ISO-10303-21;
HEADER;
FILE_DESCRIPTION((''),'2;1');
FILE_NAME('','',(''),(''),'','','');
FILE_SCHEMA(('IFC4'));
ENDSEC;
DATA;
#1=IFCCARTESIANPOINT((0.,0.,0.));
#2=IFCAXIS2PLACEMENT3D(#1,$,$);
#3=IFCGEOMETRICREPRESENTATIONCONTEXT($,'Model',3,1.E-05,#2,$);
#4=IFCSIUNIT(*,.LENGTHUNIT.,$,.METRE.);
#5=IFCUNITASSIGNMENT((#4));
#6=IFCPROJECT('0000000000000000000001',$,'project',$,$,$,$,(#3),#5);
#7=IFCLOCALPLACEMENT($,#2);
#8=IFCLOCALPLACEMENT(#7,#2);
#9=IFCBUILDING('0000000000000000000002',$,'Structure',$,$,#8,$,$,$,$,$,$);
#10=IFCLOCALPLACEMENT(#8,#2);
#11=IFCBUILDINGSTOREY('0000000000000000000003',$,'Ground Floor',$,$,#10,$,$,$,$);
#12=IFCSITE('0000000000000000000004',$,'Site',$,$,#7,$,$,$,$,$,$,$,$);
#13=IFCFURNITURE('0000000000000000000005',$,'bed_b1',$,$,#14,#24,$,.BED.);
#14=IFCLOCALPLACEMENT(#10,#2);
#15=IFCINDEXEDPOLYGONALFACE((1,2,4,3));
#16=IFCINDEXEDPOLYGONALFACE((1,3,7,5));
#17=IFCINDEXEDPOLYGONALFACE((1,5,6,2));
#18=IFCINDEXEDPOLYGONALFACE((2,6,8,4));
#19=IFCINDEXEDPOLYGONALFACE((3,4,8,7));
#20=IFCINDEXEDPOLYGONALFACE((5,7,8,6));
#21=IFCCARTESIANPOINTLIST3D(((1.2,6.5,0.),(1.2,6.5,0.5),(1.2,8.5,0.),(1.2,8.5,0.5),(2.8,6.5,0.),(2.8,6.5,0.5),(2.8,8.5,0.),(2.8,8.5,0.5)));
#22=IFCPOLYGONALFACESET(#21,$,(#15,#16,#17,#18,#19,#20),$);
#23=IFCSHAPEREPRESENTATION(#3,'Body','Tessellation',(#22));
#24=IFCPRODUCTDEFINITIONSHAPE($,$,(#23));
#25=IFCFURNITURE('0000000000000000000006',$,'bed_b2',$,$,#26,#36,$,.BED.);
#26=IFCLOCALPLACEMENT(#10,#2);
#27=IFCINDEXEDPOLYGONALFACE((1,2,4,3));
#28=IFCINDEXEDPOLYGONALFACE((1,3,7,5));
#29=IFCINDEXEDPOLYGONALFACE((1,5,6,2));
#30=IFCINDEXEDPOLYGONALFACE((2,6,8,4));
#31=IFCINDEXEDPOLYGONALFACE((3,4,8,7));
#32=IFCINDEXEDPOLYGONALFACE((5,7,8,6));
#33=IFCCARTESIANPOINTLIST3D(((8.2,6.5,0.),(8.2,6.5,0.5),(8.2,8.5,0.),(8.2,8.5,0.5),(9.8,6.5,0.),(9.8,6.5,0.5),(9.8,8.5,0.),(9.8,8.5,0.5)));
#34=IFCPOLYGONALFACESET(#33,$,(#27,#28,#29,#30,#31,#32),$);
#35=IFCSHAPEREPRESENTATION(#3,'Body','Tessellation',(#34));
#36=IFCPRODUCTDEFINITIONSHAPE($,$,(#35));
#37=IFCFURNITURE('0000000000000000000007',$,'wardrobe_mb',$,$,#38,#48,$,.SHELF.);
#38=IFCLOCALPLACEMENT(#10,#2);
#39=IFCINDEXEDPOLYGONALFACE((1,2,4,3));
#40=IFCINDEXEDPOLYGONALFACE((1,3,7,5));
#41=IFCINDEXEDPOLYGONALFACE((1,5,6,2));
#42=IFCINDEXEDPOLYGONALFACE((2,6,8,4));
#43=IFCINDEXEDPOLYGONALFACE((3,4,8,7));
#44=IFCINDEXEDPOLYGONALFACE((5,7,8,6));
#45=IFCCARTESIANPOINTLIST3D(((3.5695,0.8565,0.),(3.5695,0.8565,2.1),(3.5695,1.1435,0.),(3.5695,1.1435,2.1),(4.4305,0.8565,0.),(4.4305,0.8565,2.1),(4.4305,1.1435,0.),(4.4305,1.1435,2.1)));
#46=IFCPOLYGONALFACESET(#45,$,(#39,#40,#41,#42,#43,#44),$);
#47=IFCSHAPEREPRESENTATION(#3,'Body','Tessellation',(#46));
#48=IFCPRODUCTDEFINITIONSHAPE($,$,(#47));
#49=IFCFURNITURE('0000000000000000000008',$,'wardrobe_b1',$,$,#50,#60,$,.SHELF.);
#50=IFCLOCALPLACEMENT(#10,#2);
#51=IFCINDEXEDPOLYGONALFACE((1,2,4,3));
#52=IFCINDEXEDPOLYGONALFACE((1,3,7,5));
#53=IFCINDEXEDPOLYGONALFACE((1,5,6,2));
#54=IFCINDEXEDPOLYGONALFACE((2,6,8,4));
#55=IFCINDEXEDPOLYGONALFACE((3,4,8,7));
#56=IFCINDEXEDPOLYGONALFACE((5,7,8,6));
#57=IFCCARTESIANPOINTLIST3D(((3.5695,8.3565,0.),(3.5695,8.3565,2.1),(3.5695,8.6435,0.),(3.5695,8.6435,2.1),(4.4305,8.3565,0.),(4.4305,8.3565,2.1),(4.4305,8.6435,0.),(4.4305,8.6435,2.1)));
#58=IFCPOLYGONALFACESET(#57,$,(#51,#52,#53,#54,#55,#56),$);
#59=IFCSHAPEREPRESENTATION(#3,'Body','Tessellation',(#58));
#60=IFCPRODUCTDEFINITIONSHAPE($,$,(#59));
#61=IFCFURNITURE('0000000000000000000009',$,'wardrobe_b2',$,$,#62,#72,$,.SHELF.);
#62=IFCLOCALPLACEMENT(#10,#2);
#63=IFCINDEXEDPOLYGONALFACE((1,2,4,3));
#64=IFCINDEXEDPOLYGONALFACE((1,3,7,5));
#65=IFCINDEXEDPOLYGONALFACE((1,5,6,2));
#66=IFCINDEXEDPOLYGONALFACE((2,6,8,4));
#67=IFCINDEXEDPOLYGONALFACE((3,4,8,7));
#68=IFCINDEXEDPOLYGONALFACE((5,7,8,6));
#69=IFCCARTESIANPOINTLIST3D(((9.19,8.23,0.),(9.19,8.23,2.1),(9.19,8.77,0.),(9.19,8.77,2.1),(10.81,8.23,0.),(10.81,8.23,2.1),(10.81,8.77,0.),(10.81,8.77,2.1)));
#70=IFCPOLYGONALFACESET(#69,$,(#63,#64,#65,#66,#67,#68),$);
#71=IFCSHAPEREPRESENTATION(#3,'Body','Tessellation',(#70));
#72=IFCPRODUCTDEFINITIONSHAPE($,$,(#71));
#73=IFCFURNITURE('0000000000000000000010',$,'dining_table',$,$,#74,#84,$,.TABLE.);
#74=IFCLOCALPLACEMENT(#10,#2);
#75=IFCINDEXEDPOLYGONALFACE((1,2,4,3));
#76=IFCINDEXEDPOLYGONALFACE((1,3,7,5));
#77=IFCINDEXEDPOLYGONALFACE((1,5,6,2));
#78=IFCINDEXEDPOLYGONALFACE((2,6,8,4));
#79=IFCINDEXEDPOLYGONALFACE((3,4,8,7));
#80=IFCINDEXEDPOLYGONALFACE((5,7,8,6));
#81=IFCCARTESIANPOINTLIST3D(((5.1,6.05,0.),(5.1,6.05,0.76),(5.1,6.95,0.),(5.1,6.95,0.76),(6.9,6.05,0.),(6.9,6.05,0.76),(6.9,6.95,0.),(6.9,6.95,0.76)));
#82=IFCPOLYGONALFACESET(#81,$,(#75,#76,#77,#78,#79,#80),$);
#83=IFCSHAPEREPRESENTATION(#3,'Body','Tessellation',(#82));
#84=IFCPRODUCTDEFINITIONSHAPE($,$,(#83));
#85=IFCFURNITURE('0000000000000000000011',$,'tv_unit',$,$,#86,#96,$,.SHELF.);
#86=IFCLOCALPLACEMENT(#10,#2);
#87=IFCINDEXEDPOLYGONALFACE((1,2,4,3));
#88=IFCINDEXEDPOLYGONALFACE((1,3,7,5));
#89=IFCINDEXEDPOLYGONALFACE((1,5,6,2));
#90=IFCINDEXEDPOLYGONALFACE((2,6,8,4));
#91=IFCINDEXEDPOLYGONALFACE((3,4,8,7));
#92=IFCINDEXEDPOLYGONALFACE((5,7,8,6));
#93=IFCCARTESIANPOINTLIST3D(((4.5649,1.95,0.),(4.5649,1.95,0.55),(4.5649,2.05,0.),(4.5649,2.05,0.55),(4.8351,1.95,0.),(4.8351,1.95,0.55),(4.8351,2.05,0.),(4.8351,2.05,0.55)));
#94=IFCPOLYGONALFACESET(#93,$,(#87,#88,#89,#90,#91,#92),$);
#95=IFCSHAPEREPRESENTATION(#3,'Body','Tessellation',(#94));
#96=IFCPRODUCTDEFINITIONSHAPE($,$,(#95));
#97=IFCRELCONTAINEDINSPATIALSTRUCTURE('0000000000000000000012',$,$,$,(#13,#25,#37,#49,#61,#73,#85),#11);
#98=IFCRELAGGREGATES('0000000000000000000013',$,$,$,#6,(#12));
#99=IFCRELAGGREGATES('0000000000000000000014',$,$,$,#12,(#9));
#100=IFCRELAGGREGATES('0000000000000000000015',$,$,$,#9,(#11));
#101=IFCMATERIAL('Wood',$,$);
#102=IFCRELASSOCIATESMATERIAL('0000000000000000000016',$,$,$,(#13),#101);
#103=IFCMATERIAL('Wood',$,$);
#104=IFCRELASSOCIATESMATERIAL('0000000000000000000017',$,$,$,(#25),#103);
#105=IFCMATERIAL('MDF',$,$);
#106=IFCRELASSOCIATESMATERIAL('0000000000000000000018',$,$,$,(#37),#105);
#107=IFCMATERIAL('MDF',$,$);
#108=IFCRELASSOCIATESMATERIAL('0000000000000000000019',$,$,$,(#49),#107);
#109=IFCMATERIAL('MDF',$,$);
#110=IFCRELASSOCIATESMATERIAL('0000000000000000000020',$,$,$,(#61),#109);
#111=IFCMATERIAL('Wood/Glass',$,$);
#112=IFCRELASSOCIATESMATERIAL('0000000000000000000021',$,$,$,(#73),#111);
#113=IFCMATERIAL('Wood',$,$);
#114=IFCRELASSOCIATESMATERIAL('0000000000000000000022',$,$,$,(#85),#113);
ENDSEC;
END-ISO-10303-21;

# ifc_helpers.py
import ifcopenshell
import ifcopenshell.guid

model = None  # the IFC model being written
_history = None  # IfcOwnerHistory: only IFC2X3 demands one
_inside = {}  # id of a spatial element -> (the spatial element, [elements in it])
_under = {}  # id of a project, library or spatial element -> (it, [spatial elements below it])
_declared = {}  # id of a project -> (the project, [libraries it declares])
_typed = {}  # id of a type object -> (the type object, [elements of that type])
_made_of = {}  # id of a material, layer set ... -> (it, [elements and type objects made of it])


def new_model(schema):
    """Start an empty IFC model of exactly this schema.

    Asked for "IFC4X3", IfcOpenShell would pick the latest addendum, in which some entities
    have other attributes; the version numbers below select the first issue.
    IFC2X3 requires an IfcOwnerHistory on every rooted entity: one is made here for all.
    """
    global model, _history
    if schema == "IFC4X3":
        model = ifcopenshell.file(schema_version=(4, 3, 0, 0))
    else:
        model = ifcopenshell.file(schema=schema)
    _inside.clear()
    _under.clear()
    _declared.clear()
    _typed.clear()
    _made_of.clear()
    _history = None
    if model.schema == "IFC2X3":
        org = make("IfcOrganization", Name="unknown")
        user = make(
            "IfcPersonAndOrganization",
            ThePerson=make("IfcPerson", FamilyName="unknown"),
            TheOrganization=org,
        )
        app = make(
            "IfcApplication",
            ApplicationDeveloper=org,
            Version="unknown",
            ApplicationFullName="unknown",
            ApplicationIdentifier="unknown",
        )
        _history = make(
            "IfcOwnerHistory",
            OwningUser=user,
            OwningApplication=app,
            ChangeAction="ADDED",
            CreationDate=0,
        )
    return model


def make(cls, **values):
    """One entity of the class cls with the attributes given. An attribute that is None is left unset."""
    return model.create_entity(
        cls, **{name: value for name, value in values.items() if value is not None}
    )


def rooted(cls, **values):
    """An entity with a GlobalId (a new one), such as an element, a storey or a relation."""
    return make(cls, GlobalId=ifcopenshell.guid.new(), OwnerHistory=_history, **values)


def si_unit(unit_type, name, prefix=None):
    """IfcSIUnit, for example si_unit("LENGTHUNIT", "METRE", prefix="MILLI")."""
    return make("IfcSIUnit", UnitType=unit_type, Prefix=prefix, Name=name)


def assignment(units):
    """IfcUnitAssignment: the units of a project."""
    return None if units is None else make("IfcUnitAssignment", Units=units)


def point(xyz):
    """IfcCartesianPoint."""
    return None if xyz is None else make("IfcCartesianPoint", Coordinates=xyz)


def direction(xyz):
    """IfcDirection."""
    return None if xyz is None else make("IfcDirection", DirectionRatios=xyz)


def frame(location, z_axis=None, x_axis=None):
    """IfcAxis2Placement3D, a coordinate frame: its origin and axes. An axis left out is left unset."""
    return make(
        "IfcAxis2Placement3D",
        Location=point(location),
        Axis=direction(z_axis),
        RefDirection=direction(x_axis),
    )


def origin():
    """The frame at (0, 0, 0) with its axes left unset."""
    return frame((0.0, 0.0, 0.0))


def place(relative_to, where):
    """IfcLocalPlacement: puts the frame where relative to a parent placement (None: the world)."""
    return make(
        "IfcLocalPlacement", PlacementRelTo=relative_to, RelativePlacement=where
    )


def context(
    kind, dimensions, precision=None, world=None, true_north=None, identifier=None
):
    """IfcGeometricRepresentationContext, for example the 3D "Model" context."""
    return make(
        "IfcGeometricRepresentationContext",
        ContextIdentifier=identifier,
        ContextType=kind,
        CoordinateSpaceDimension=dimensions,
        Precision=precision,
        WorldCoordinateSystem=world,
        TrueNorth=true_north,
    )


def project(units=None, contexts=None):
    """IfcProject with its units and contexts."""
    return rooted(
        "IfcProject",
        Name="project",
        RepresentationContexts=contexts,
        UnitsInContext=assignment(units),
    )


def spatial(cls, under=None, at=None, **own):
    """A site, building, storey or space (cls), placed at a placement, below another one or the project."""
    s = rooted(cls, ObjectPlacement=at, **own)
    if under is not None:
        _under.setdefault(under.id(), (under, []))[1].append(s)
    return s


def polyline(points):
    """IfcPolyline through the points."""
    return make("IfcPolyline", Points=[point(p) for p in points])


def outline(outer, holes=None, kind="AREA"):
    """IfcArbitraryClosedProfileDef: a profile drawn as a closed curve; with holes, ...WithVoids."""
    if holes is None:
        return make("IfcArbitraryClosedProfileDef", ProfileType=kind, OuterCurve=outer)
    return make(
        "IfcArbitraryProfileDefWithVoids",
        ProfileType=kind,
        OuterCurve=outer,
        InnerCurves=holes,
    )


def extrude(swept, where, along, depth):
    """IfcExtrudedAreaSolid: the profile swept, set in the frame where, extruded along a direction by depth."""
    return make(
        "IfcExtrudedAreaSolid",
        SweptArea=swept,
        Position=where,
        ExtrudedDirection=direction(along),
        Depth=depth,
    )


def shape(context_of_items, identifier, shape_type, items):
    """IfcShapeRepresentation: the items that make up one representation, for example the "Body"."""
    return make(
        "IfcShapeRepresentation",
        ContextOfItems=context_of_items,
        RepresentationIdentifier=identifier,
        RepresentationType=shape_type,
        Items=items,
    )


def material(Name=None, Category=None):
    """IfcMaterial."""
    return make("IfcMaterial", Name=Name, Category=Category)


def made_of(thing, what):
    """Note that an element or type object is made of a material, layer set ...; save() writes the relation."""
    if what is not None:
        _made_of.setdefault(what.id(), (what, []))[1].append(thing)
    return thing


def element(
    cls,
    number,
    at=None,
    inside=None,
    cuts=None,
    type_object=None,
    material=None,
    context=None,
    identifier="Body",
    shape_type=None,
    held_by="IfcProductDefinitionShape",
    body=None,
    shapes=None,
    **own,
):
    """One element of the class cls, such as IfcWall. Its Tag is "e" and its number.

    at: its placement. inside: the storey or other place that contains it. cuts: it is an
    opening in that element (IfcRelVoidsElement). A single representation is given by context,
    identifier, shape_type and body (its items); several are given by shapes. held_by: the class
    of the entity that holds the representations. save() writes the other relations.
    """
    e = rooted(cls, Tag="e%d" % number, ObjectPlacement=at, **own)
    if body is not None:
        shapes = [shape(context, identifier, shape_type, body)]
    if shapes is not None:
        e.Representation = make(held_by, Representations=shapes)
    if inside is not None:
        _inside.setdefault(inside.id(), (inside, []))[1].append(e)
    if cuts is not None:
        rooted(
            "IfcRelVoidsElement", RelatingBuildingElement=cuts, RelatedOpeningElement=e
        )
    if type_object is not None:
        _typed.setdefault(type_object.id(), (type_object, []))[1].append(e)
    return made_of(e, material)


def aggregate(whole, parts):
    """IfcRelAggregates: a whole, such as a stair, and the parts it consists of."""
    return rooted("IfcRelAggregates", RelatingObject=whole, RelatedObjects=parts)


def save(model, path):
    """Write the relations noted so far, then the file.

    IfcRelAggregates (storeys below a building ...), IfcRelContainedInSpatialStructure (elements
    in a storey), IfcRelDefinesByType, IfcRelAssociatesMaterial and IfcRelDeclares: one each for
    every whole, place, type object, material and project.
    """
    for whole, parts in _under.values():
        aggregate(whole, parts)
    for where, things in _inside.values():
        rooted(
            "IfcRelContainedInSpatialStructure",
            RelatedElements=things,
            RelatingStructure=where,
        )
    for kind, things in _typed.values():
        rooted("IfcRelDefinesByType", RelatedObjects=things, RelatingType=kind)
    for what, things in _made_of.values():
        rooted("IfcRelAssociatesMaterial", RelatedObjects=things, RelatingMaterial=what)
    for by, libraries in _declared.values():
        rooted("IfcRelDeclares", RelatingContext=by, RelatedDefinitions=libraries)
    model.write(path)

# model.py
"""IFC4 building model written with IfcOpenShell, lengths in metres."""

from ifc_helpers import new_model, si_unit, frame, origin, place, context, project, spatial, polyline, outline, extrude, material, element, save


model = new_model("IFC4")

# Units and contexts
model_context = context("Model", 3, precision=1e-05, world=origin())
ifc_project = project(units=[si_unit("LENGTHUNIT", "METRE")], contexts=[model_context])

# Site, building, storey
site_placement = place(None, origin())
site = spatial("IfcSite", under=ifc_project, at=site_placement, Name="Site")
building_placement = place(site_placement, origin())
building = spatial("IfcBuilding", under=site, at=building_placement, Name="Structure")
storey_placement = place(building_placement, origin())
storey = spatial("IfcBuildingStorey", under=building, at=storey_placement, Name="Ground Floor")

# Furniture
ifc_material_1 = material(Name="Wood")
furniture_1_placement = place(storey_placement, frame((2.0, 7.5, 0.0)))
element("IfcFurniture", 1, at=furniture_1_placement, inside=storey, material=ifc_material_1, Name="bed_b1", PredefinedType="BED", context=model_context, shape_type="SweptSolid", body=[
    extrude(outline(polyline([(-0.8, -1.0), (0.8, -1.0), (0.8, 1.0), (-0.8, 1.0), (-0.8, -1.0)])), origin(), (0.0, 0.0, 1.0), 0.5),
])
ifc_material_2 = material(Name="Wood")
furniture_2_placement = place(storey_placement, frame((9.0, 7.5, 0.0)))
element("IfcFurniture", 2, at=furniture_2_placement, inside=storey, material=ifc_material_2, Name="bed_b2", PredefinedType="BED", context=model_context, shape_type="SweptSolid", body=[
    extrude(outline(polyline([(-0.8, -1.0), (0.8, -1.0), (0.8, 1.0), (-0.8, 1.0), (-0.8, -1.0)])), origin(), (0.0, 0.0, 1.0), 0.5),
])
ifc_material_3 = material(Name="MDF")
furniture_3_placement = place(storey_placement, frame((4.0, 1.0, 0.0)))
element("IfcFurniture", 3, at=furniture_3_placement, inside=storey, material=ifc_material_3, Name="wardrobe_mb", PredefinedType="SHELF", context=model_context, shape_type="SweptSolid", body=[
    extrude(outline(polyline([(-0.4305, -0.1435), (0.4305, -0.1435), (0.4305, 0.1435), (-0.4305, 0.1435), (-0.4305, -0.1435)])), origin(), (0.0, 0.0, 1.0), 2.1),
])
ifc_material_4 = material(Name="MDF")
furniture_4_placement = place(storey_placement, frame((4.0, 8.5, 0.0)))
element("IfcFurniture", 4, at=furniture_4_placement, inside=storey, material=ifc_material_4, Name="wardrobe_b1", PredefinedType="SHELF", context=model_context, shape_type="SweptSolid", body=[
    extrude(outline(polyline([(-0.4305, -0.1435), (0.4305, -0.1435), (0.4305, 0.1435), (-0.4305, 0.1435), (-0.4305, -0.1435)])), origin(), (0.0, 0.0, 1.0), 2.1),
])
ifc_material_5 = material(Name="MDF")
furniture_5_placement = place(storey_placement, frame((10.0, 8.5, 0.0)))
element("IfcFurniture", 5, at=furniture_5_placement, inside=storey, material=ifc_material_5, Name="wardrobe_b2", PredefinedType="SHELF", context=model_context, shape_type="SweptSolid", body=[
    extrude(outline(polyline([(-0.81, -0.27), (0.81, -0.27), (0.81, 0.27), (-0.81, 0.27), (-0.81, -0.27)])), origin(), (0.0, 0.0, 1.0), 2.1),
])
ifc_material_6 = material(Name="Wood/Glass")
furniture_6_placement = place(storey_placement, frame((6.0, 6.5, 0.0)))
element("IfcFurniture", 6, at=furniture_6_placement, inside=storey, material=ifc_material_6, Name="dining_table", PredefinedType="TABLE", context=model_context, shape_type="SweptSolid", body=[
    extrude(outline(polyline([(-0.9, -0.45), (0.9, -0.45), (0.9, 0.45), (-0.9, 0.45), (-0.9, -0.45)])), origin(), (0.0, 0.0, 1.0), 0.76),
])
ifc_material_7 = material(Name="Wood")
furniture_7_placement = place(storey_placement, frame((4.7, 2.0, 0.0)))
element("IfcFurniture", 7, at=furniture_7_placement, inside=storey, material=ifc_material_7, Name="tv_unit", PredefinedType="SHELF", context=model_context, shape_type="SweptSolid", body=[
    extrude(outline(polyline([(-0.1351, -0.05), (0.1351, -0.05), (0.1351, 0.05), (-0.1351, 0.05), (-0.1351, -0.05)])), origin(), (0.0, 0.0, 1.0), 0.55),
])

save(model, "model.ifc")
